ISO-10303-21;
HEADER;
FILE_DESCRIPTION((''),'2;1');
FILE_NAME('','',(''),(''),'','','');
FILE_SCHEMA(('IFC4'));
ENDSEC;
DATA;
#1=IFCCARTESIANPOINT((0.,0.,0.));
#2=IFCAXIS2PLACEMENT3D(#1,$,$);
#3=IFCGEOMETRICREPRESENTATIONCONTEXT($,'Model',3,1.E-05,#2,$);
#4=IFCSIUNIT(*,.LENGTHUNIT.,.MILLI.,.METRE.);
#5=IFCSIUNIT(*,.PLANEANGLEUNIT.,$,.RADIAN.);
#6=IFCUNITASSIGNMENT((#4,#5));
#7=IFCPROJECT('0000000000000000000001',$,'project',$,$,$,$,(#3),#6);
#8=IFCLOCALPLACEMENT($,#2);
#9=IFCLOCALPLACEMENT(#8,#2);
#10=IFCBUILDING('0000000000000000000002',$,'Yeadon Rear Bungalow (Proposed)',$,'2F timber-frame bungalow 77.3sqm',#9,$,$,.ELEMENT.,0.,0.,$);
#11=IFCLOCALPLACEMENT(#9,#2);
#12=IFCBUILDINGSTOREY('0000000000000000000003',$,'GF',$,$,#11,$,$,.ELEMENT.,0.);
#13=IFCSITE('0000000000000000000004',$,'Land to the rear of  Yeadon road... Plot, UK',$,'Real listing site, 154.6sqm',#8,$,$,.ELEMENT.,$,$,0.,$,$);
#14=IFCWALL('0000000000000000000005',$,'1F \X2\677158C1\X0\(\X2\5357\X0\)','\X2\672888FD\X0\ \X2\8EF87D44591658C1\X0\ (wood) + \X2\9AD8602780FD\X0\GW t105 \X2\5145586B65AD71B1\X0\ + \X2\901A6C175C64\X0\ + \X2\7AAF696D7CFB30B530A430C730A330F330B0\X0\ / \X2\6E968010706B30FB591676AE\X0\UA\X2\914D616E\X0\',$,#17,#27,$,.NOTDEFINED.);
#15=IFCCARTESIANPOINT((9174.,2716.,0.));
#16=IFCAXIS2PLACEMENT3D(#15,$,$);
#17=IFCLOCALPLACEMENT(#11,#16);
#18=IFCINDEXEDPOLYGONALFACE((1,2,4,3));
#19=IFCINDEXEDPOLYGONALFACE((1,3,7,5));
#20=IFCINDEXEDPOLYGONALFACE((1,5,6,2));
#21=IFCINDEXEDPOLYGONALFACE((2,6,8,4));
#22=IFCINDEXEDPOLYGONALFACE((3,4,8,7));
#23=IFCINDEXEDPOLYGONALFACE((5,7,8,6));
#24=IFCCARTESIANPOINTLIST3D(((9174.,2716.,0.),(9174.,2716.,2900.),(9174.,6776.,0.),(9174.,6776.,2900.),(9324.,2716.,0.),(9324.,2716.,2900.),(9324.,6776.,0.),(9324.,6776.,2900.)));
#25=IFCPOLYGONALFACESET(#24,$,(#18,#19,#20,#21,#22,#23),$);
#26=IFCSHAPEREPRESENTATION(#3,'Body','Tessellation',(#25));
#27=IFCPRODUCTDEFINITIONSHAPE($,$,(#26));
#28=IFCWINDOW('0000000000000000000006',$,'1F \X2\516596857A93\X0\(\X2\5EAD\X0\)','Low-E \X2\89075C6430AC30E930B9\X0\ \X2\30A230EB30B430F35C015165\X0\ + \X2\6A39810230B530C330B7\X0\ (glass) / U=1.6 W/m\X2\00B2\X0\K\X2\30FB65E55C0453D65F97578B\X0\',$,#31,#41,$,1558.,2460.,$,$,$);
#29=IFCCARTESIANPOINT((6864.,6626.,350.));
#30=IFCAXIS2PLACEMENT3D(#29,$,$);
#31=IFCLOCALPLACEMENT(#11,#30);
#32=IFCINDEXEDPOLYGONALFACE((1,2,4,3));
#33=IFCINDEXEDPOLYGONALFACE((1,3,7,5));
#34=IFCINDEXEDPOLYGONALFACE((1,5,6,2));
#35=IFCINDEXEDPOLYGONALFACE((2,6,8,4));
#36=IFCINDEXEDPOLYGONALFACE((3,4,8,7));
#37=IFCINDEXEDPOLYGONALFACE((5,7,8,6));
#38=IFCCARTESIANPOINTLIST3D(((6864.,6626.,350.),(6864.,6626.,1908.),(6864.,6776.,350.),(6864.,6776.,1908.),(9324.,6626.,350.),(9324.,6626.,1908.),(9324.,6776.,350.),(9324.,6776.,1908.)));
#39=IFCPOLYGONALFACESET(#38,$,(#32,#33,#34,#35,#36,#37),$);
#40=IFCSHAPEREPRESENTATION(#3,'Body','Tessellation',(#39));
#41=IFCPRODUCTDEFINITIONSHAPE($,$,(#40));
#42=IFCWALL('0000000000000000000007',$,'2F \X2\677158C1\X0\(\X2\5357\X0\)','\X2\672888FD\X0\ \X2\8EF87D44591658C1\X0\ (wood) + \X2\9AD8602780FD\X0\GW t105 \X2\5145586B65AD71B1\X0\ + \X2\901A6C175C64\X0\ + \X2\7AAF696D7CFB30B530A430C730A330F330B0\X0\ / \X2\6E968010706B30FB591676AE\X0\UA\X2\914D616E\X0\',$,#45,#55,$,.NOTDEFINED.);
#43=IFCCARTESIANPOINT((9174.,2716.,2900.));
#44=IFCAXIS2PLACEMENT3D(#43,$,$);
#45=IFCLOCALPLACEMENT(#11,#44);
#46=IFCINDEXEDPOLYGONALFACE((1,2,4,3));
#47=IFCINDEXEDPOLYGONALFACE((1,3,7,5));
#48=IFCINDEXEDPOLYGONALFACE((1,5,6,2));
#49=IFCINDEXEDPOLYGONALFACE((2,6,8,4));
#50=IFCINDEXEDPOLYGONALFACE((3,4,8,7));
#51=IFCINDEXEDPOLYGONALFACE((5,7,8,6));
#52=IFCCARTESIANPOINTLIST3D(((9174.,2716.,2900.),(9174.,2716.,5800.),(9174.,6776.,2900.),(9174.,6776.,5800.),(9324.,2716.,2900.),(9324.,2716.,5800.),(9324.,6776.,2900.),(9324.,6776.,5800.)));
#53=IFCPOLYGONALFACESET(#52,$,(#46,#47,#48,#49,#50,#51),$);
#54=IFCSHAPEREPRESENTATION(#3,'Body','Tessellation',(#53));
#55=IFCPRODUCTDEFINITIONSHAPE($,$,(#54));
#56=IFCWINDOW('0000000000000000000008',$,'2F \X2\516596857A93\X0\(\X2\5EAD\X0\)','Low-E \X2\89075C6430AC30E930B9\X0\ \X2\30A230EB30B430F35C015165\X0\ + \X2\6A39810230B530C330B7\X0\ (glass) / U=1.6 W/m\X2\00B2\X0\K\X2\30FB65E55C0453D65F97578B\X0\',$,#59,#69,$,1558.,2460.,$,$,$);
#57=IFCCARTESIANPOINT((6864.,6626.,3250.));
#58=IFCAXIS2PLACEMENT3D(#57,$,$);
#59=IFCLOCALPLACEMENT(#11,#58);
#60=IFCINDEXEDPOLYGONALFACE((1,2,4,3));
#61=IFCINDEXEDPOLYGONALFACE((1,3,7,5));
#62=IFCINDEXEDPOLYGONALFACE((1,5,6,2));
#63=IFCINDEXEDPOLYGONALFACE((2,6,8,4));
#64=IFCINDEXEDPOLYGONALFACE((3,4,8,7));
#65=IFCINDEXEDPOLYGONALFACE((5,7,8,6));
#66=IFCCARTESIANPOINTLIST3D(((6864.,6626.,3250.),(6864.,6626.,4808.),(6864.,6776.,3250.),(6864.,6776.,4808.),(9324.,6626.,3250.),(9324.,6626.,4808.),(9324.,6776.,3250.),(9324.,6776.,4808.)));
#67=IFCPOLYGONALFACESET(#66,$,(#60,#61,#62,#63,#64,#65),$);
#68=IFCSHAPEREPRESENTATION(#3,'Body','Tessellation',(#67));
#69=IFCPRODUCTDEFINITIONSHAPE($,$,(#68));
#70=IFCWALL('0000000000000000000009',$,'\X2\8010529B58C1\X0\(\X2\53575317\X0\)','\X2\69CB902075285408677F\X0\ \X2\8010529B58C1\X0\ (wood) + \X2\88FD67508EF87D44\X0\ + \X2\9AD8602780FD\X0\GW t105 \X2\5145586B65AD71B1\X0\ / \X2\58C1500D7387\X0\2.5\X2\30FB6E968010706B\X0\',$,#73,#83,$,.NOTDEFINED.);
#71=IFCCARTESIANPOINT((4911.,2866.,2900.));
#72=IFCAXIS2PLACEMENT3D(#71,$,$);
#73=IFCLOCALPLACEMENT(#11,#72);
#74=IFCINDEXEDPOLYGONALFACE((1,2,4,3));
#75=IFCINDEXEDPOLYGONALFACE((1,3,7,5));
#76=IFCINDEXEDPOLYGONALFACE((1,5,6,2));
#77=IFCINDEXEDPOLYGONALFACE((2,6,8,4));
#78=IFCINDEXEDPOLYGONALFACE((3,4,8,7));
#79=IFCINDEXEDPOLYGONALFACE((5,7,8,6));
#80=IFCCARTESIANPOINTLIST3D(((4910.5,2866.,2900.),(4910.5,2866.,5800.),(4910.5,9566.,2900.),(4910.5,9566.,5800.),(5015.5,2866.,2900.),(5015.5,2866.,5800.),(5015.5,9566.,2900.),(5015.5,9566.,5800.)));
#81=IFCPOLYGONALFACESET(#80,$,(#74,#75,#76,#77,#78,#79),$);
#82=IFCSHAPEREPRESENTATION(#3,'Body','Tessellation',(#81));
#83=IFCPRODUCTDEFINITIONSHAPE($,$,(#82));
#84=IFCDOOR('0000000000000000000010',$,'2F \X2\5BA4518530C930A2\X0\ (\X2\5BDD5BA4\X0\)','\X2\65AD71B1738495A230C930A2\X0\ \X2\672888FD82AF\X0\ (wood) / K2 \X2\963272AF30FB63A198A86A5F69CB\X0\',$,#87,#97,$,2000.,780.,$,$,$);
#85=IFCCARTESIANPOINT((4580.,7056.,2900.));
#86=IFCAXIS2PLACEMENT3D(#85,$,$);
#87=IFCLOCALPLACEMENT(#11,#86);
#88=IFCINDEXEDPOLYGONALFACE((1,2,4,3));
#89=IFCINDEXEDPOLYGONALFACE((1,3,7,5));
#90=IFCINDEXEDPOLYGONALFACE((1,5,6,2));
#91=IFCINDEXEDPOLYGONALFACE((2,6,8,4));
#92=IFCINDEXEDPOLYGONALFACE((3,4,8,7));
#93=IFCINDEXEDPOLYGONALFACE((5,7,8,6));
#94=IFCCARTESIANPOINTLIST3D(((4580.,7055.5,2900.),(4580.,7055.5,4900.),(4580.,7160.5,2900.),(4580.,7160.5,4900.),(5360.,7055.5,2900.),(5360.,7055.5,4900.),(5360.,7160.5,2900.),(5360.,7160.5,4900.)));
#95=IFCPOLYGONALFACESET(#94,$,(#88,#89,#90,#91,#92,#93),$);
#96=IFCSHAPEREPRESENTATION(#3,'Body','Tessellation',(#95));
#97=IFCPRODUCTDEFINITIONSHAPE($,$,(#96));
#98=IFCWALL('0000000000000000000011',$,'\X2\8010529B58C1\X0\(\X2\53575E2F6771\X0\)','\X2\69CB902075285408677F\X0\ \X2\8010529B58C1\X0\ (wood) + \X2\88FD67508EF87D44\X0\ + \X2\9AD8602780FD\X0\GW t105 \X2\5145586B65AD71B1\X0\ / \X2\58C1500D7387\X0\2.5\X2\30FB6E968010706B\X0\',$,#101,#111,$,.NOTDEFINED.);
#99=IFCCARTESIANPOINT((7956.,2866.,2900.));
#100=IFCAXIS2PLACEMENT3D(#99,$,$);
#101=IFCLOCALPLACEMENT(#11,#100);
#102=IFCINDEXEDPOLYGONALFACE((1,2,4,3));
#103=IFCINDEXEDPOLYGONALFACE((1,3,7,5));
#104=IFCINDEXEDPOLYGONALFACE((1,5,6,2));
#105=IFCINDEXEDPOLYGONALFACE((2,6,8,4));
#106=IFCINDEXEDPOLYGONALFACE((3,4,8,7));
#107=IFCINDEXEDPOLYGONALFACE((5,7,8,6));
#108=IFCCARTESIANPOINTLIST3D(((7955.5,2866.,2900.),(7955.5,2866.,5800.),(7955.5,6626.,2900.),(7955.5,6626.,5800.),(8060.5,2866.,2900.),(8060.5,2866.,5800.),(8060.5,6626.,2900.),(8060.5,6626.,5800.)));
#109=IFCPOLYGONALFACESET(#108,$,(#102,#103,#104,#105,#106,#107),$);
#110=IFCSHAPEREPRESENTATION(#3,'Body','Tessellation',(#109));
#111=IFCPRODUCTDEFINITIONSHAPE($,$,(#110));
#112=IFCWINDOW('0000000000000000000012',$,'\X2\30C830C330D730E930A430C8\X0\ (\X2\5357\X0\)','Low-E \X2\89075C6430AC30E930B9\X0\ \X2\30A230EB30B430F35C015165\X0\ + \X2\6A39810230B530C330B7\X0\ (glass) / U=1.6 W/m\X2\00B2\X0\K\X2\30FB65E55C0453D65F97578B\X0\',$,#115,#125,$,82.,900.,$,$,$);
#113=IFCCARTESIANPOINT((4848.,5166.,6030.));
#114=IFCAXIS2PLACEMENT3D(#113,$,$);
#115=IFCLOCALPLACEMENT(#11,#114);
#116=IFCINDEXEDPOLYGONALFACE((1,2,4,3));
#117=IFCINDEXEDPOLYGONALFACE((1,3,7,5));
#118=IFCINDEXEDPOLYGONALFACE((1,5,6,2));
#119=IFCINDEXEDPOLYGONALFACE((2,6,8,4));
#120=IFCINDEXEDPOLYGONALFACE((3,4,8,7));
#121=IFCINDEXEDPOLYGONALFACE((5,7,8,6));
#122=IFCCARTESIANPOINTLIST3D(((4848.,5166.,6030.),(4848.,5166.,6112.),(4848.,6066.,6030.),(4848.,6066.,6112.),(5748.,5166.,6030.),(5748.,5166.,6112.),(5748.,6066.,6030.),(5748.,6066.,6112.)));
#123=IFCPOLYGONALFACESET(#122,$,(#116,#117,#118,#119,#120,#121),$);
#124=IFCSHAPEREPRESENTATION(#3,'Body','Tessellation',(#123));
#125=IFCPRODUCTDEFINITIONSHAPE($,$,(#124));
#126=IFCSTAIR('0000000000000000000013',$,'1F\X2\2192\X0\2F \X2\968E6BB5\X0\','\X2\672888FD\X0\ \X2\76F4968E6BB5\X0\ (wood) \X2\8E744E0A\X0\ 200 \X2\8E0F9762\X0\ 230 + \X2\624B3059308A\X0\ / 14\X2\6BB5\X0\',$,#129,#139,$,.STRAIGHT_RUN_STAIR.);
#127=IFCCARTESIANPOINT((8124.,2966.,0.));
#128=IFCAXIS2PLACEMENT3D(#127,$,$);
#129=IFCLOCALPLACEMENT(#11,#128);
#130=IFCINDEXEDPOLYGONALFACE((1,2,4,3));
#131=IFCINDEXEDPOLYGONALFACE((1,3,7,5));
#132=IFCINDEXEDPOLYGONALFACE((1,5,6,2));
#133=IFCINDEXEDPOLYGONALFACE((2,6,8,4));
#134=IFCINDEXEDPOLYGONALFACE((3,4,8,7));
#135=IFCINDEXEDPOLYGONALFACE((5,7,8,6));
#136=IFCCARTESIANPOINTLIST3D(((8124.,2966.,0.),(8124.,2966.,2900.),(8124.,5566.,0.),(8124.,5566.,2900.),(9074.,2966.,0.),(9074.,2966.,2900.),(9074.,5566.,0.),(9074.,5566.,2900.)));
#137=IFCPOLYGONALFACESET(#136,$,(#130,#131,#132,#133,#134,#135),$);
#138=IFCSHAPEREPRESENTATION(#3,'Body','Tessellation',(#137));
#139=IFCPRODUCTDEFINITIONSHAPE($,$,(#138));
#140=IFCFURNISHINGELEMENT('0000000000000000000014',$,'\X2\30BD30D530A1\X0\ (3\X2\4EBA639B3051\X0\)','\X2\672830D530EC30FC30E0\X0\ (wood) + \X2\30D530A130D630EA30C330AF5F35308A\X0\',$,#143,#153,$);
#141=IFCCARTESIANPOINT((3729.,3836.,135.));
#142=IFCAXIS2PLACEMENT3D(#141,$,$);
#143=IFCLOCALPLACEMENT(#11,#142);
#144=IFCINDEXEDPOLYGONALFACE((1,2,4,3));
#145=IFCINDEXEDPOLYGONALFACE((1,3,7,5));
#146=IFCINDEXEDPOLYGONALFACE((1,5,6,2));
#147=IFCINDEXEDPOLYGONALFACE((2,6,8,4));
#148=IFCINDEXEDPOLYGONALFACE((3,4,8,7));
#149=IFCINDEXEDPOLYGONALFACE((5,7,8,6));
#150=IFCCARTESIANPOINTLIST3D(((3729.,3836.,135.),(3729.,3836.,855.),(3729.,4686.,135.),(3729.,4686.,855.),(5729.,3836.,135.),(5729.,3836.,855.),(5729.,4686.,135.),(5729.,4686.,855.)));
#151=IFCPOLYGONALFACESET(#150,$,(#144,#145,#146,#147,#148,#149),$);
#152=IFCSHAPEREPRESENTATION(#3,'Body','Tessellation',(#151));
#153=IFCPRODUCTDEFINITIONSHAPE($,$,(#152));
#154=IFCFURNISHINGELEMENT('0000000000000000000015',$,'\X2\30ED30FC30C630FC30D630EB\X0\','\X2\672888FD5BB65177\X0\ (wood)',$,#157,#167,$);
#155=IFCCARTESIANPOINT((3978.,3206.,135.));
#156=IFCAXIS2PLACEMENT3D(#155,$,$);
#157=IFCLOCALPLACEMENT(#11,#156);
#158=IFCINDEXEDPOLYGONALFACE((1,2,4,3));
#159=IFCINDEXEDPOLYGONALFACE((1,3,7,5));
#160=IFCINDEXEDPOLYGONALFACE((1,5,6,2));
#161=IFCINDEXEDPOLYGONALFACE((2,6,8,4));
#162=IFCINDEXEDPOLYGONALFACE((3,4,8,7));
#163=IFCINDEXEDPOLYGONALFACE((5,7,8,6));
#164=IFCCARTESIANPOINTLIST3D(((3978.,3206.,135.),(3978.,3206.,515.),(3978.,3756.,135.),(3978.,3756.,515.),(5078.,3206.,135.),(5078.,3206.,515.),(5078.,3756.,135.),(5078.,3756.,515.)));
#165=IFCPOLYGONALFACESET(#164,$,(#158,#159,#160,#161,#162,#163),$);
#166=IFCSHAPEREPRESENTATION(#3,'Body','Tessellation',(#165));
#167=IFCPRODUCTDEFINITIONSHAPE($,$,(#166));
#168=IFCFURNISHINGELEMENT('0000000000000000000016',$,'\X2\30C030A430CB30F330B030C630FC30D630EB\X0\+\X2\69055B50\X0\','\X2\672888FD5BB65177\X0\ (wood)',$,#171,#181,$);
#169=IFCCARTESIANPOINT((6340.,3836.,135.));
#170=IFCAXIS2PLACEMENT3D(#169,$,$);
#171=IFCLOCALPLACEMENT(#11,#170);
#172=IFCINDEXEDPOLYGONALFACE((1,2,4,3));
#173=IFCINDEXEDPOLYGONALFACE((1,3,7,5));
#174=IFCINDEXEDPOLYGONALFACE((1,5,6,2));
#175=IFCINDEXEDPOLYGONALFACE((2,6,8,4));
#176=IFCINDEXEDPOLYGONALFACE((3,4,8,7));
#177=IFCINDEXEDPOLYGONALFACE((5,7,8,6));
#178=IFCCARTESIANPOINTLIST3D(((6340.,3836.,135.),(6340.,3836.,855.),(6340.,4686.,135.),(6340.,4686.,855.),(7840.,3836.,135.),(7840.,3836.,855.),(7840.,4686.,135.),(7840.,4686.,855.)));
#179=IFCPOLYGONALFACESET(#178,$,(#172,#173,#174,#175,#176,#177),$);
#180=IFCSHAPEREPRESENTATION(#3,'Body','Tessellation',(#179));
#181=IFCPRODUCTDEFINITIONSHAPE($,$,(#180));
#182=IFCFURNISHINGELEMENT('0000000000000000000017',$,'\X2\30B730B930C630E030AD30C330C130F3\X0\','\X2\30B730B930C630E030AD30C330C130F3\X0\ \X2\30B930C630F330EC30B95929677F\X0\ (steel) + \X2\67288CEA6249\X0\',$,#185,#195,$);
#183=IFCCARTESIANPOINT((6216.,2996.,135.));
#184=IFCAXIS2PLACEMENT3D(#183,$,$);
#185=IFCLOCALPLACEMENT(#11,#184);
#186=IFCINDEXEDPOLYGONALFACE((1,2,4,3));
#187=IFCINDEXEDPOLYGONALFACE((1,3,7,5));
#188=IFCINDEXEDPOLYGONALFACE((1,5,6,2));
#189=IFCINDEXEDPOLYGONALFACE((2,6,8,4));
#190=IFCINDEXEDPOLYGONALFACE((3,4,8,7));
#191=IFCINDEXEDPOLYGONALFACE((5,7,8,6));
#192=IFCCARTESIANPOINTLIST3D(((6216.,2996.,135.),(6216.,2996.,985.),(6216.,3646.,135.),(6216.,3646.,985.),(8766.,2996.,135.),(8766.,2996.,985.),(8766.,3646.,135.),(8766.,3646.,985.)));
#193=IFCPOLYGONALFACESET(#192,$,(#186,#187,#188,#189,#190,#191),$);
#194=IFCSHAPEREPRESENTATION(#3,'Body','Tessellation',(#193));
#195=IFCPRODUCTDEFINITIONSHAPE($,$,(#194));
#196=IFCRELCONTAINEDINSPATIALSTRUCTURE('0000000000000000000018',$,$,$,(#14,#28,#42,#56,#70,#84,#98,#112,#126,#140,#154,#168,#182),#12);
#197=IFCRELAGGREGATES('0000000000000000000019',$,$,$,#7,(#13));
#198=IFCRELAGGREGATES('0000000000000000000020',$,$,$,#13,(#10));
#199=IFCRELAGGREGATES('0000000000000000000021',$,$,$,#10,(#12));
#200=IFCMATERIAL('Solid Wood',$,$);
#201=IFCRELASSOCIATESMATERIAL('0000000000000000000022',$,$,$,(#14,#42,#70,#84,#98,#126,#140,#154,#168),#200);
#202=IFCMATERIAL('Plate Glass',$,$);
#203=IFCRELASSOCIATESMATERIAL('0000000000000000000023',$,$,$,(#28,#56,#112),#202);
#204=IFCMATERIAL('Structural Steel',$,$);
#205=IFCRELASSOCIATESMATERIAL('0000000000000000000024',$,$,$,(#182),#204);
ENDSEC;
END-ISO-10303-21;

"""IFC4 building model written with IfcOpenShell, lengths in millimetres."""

from ifc_helpers import new_model, si_unit, frame, frame_2d, origin, place, context, project, spatial, rectangle, extrude, material, element, fill, save


model = new_model("IFC4")

# Units and contexts
model_context = context("Model", 3, precision=1e-05, world=origin())
ifc_project = project(units=[si_unit("LENGTHUNIT", "METRE", prefix="MILLI"), si_unit("PLANEANGLEUNIT", "RADIAN")], contexts=[model_context])

# Site, building, storey
site_placement = place(None, origin())
site = spatial("IfcSite", under=ifc_project, at=site_placement, Name="Land to the rear of  Yeadon road... Plot, UK", ObjectType="Real listing site, 154.6sqm", CompositionType="ELEMENT", RefElevation=0.0)
building_placement = place(site_placement, origin())
building = spatial("IfcBuilding", under=site, at=building_placement, Name="Yeadon Rear Bungalow (Proposed)", ObjectType="2F timber-frame bungalow 77.3sqm", CompositionType="ELEMENT", ElevationOfRefHeight=0.0, ElevationOfTerrain=0.0)
storey_placement = place(building_placement, origin())
storey = spatial("IfcBuildingStorey", under=building, at=storey_placement, Name="GF", CompositionType="ELEMENT", Elevation=0.0)

# Wall, opening, window
ifc_material_1 = material(Name="Solid Wood")
wall_1_placement = place(storey_placement, frame((9174.0, 2716.0, 0.0)))
wall_1 = element("IfcWall", 1, at=wall_1_placement, inside=storey, material=ifc_material_1, Name="1F 東壁(南)", Description="木製 軸組外壁 (wood) + 高性能GW t105 充填断熱 + 通気層 + 窯業系サイディング / 準耐火・外皮UA配慮", PredefinedType="NOTDEFINED", context=model_context, shape_type="SweptSolid", body=[
    extrude(rectangle(XDim=150.0, YDim=4060.0, at=frame_2d((75.0, 2030.0))), frame((9174.0, 2716.0, 0.0)), (0.0, 0.0, 1.0), 2900.0),
])
opening_1_placement = place(storey_placement, frame((6864.0, 6626.0, 350.0)))
opening_1 = element("IfcOpeningElement", 2, at=opening_1_placement, cuts=wall_1, PredefinedType="NOTDEFINED", context=model_context, shape_type="SweptSolid", body=[
    extrude(rectangle(XDim=2460.0, YDim=150.0, at=frame_2d((1230.0, 75.0))), frame((6864.0, 6626.0, 350.0)), (0.0, 0.0, 1.0), 1558.0),
])
ifc_material_2 = material(Name="Plate Glass")
window_1_placement = place(storey_placement, frame((6864.0, 6626.0, 350.0)))
window_1 = element("IfcWindow", 3, at=window_1_placement, inside=storey, material=ifc_material_2, Name="1F 入隅窓(庭)", Description="Low-E 複層ガラス アルゴン封入 + 樹脂サッシ (glass) / U=1.6 W/m²K・日射取得型", OverallHeight=1558.0, OverallWidth=2460.0, context=model_context, shape_type="SweptSolid", body=[
    extrude(rectangle(XDim=2460.0, YDim=150.0, at=frame_2d((1230.0, 75.0))), frame((6864.0, 6626.0, 350.0)), (0.0, 0.0, 1.0), 1558.0),
])
fill(opening_1, window_1)

# Wall, opening, window
wall_2_placement = place(storey_placement, frame((9174.0, 2716.0, 2900.0)))
wall_2 = element("IfcWall", 4, at=wall_2_placement, inside=storey, material=ifc_material_1, Name="2F 東壁(南)", Description="木製 軸組外壁 (wood) + 高性能GW t105 充填断熱 + 通気層 + 窯業系サイディング / 準耐火・外皮UA配慮", PredefinedType="NOTDEFINED", context=model_context, shape_type="SweptSolid", body=[
    extrude(rectangle(XDim=150.0, YDim=4060.0, at=frame_2d((75.0, 2030.0))), frame((9174.0, 2716.0, 2900.0)), (0.0, 0.0, 1.0), 2900.0),
])
opening_2_placement = place(storey_placement, frame((6864.0, 6626.0, 3250.0)))
opening_2 = element("IfcOpeningElement", 5, at=opening_2_placement, cuts=wall_2, PredefinedType="NOTDEFINED", context=model_context, shape_type="SweptSolid", body=[
    extrude(rectangle(XDim=2460.0, YDim=150.0, at=frame_2d((1230.0, 75.0))), frame((6864.0, 6626.0, 3250.0)), (0.0, 0.0, 1.0), 1558.0),
])
window_2_placement = place(storey_placement, frame((6864.0, 6626.0, 3250.0)))
window_2 = element("IfcWindow", 6, at=window_2_placement, inside=storey, material=ifc_material_2, Name="2F 入隅窓(庭)", Description="Low-E 複層ガラス アルゴン封入 + 樹脂サッシ (glass) / U=1.6 W/m²K・日射取得型", OverallHeight=1558.0, OverallWidth=2460.0, context=model_context, shape_type="SweptSolid", body=[
    extrude(rectangle(XDim=2460.0, YDim=150.0, at=frame_2d((1230.0, 75.0))), frame((6864.0, 6626.0, 3250.0)), (0.0, 0.0, 1.0), 1558.0),
])
fill(opening_2, window_2)

# Wall, opening, door
wall_3_placement = place(storey_placement, frame((4911.0, 2866.0, 2900.0)))
wall_3 = element("IfcWall", 7, at=wall_3_placement, inside=storey, material=ifc_material_1, Name="耐力壁(南北)", Description="構造用合板 耐力壁 (wood) + 製材軸組 + 高性能GW t105 充填断熱 / 壁倍率2.5・準耐火", PredefinedType="NOTDEFINED", context=model_context, shape_type="SweptSolid", body=[
    extrude(rectangle(XDim=105.0, YDim=6700.0, at=frame_2d((52.0, 3350.0))), frame((4911.0, 2866.0, 2900.0)), (0.0, 0.0, 1.0), 2900.0),
])
opening_3_placement = place(storey_placement, frame((4580.0, 7056.0, 2900.0)))
opening_3 = element("IfcOpeningElement", 8, at=opening_3_placement, cuts=wall_3, PredefinedType="NOTDEFINED", context=model_context, shape_type="SweptSolid", body=[
    extrude(rectangle(XDim=780.0, YDim=105.0, at=frame_2d((390.0, 52.0))), frame((4580.0, 7056.0, 2900.0)), (0.0, 0.0, 1.0), 2000.0),
])
door_1_placement = place(storey_placement, frame((4580.0, 7056.0, 2900.0)))
door_1 = element("IfcDoor", 9, at=door_1_placement, inside=storey, material=ifc_material_1, Name="2F 室内ドア (寝室)", Description="断熱玄関ドア 木製芯 (wood) / K2 防犯・採風機構", OverallHeight=2000.0, OverallWidth=780.0, context=model_context, shape_type="SweptSolid", body=[
    extrude(rectangle(XDim=780.0, YDim=105.0, at=frame_2d((390.0, 52.0))), frame((4580.0, 7056.0, 2900.0)), (0.0, 0.0, 1.0), 2000.0),
])
fill(opening_3, door_1)

# Wall
wall_4_placement = place(storey_placement, frame((7956.0, 2866.0, 2900.0)))
element("IfcWall", 10, at=wall_4_placement, inside=storey, material=ifc_material_1, Name="耐力壁(南帯東)", Description="構造用合板 耐力壁 (wood) + 製材軸組 + 高性能GW t105 充填断熱 / 壁倍率2.5・準耐火", PredefinedType="NOTDEFINED", context=model_context, shape_type="SweptSolid", body=[
    extrude(rectangle(XDim=105.0, YDim=3760.0, at=frame_2d((52.0, 1880.0))), frame((7956.0, 2866.0, 2900.0)), (0.0, 0.0, 1.0), 2900.0),
])

# Window
window_3_placement = place(storey_placement, frame((4848.0, 5166.0, 6030.0)))
element("IfcWindow", 11, at=window_3_placement, inside=storey, material=ifc_material_2, Name="トップライト (南)", Description="Low-E 複層ガラス アルゴン封入 + 樹脂サッシ (glass) / U=1.6 W/m²K・日射取得型", OverallHeight=82.0, OverallWidth=900.0, context=model_context, shape_type="SweptSolid", body=[
    extrude(rectangle(XDim=900.0, YDim=900.0, at=frame_2d((450.0, 450.0))), frame((4848.0, 5166.0, 6030.0)), (0.0, 0.0, 1.0), 82.0),
])

# Stair
stair_placement = place(storey_placement, frame((8124.0, 2966.0, 0.0)))
element("IfcStair", 12, at=stair_placement, inside=storey, material=ifc_material_1, Name="1F→2F 階段", Description="木製 直階段 (wood) 蹴上 200 踏面 230 + 手すり / 14段", PredefinedType="STRAIGHT_RUN_STAIR", context=model_context, shape_type="SweptSolid", body=[
    extrude(rectangle(XDim=950.0, YDim=2600.0, at=frame_2d((475.0, 1300.0))), frame((8124.0, 2966.0, 0.0)), (0.0, 0.0, 1.0), 2900.0),
])

# Furnishing elements
furnishing_1_placement = place(storey_placement, frame((3729.0, 3836.0, 135.0)))
element("IfcFurnishingElement", 13, at=furnishing_1_placement, inside=storey, material=ifc_material_1, Name="ソファ (3人掛け)", Description="木フレーム (wood) + ファブリック張り", context=model_context, shape_type="SweptSolid", body=[
    extrude(rectangle(XDim=2000.0, YDim=850.0, at=frame_2d((1000.0, 425.0))), frame((3729.0, 3836.0, 135.0)), (0.0, 0.0, 1.0), 720.0),
])
furnishing_2_placement = place(storey_placement, frame((3978.0, 3206.0, 135.0)))
element("IfcFurnishingElement", 14, at=furnishing_2_placement, inside=storey, material=ifc_material_1, Name="ローテーブル", Description="木製家具 (wood)", context=model_context, shape_type="SweptSolid", body=[
    extrude(rectangle(XDim=1100.0, YDim=550.0, at=frame_2d((550.0, 275.0))), frame((3978.0, 3206.0, 135.0)), (0.0, 0.0, 1.0), 380.0),
])
furnishing_3_placement = place(storey_placement, frame((6340.0, 3836.0, 135.0)))
element("IfcFurnishingElement", 15, at=furnishing_3_placement, inside=storey, material=ifc_material_1, Name="ダイニングテーブル+椅子", Description="木製家具 (wood)", context=model_context, shape_type="SweptSolid", body=[
    extrude(rectangle(XDim=1500.0, YDim=850.0, at=frame_2d((750.0, 425.0))), frame((6340.0, 3836.0, 135.0)), (0.0, 0.0, 1.0), 720.0),
])
ifc_material_3 = material(Name="Structural Steel")
furnishing_4_placement = place(storey_placement, frame((6216.0, 2996.0, 135.0)))
element("IfcFurnishingElement", 16, at=furnishing_4_placement, inside=storey, material=ifc_material_3, Name="システムキッチン", Description="システムキッチン ステンレス天板 (steel) + 木質扉", context=model_context, shape_type="SweptSolid", body=[
    extrude(rectangle(XDim=2550.0, YDim=650.0, at=frame_2d((1275.0, 325.0))), frame((6216.0, 2996.0, 135.0)), (0.0, 0.0, 1.0), 850.0),
])

save(model, "model.ifc")
